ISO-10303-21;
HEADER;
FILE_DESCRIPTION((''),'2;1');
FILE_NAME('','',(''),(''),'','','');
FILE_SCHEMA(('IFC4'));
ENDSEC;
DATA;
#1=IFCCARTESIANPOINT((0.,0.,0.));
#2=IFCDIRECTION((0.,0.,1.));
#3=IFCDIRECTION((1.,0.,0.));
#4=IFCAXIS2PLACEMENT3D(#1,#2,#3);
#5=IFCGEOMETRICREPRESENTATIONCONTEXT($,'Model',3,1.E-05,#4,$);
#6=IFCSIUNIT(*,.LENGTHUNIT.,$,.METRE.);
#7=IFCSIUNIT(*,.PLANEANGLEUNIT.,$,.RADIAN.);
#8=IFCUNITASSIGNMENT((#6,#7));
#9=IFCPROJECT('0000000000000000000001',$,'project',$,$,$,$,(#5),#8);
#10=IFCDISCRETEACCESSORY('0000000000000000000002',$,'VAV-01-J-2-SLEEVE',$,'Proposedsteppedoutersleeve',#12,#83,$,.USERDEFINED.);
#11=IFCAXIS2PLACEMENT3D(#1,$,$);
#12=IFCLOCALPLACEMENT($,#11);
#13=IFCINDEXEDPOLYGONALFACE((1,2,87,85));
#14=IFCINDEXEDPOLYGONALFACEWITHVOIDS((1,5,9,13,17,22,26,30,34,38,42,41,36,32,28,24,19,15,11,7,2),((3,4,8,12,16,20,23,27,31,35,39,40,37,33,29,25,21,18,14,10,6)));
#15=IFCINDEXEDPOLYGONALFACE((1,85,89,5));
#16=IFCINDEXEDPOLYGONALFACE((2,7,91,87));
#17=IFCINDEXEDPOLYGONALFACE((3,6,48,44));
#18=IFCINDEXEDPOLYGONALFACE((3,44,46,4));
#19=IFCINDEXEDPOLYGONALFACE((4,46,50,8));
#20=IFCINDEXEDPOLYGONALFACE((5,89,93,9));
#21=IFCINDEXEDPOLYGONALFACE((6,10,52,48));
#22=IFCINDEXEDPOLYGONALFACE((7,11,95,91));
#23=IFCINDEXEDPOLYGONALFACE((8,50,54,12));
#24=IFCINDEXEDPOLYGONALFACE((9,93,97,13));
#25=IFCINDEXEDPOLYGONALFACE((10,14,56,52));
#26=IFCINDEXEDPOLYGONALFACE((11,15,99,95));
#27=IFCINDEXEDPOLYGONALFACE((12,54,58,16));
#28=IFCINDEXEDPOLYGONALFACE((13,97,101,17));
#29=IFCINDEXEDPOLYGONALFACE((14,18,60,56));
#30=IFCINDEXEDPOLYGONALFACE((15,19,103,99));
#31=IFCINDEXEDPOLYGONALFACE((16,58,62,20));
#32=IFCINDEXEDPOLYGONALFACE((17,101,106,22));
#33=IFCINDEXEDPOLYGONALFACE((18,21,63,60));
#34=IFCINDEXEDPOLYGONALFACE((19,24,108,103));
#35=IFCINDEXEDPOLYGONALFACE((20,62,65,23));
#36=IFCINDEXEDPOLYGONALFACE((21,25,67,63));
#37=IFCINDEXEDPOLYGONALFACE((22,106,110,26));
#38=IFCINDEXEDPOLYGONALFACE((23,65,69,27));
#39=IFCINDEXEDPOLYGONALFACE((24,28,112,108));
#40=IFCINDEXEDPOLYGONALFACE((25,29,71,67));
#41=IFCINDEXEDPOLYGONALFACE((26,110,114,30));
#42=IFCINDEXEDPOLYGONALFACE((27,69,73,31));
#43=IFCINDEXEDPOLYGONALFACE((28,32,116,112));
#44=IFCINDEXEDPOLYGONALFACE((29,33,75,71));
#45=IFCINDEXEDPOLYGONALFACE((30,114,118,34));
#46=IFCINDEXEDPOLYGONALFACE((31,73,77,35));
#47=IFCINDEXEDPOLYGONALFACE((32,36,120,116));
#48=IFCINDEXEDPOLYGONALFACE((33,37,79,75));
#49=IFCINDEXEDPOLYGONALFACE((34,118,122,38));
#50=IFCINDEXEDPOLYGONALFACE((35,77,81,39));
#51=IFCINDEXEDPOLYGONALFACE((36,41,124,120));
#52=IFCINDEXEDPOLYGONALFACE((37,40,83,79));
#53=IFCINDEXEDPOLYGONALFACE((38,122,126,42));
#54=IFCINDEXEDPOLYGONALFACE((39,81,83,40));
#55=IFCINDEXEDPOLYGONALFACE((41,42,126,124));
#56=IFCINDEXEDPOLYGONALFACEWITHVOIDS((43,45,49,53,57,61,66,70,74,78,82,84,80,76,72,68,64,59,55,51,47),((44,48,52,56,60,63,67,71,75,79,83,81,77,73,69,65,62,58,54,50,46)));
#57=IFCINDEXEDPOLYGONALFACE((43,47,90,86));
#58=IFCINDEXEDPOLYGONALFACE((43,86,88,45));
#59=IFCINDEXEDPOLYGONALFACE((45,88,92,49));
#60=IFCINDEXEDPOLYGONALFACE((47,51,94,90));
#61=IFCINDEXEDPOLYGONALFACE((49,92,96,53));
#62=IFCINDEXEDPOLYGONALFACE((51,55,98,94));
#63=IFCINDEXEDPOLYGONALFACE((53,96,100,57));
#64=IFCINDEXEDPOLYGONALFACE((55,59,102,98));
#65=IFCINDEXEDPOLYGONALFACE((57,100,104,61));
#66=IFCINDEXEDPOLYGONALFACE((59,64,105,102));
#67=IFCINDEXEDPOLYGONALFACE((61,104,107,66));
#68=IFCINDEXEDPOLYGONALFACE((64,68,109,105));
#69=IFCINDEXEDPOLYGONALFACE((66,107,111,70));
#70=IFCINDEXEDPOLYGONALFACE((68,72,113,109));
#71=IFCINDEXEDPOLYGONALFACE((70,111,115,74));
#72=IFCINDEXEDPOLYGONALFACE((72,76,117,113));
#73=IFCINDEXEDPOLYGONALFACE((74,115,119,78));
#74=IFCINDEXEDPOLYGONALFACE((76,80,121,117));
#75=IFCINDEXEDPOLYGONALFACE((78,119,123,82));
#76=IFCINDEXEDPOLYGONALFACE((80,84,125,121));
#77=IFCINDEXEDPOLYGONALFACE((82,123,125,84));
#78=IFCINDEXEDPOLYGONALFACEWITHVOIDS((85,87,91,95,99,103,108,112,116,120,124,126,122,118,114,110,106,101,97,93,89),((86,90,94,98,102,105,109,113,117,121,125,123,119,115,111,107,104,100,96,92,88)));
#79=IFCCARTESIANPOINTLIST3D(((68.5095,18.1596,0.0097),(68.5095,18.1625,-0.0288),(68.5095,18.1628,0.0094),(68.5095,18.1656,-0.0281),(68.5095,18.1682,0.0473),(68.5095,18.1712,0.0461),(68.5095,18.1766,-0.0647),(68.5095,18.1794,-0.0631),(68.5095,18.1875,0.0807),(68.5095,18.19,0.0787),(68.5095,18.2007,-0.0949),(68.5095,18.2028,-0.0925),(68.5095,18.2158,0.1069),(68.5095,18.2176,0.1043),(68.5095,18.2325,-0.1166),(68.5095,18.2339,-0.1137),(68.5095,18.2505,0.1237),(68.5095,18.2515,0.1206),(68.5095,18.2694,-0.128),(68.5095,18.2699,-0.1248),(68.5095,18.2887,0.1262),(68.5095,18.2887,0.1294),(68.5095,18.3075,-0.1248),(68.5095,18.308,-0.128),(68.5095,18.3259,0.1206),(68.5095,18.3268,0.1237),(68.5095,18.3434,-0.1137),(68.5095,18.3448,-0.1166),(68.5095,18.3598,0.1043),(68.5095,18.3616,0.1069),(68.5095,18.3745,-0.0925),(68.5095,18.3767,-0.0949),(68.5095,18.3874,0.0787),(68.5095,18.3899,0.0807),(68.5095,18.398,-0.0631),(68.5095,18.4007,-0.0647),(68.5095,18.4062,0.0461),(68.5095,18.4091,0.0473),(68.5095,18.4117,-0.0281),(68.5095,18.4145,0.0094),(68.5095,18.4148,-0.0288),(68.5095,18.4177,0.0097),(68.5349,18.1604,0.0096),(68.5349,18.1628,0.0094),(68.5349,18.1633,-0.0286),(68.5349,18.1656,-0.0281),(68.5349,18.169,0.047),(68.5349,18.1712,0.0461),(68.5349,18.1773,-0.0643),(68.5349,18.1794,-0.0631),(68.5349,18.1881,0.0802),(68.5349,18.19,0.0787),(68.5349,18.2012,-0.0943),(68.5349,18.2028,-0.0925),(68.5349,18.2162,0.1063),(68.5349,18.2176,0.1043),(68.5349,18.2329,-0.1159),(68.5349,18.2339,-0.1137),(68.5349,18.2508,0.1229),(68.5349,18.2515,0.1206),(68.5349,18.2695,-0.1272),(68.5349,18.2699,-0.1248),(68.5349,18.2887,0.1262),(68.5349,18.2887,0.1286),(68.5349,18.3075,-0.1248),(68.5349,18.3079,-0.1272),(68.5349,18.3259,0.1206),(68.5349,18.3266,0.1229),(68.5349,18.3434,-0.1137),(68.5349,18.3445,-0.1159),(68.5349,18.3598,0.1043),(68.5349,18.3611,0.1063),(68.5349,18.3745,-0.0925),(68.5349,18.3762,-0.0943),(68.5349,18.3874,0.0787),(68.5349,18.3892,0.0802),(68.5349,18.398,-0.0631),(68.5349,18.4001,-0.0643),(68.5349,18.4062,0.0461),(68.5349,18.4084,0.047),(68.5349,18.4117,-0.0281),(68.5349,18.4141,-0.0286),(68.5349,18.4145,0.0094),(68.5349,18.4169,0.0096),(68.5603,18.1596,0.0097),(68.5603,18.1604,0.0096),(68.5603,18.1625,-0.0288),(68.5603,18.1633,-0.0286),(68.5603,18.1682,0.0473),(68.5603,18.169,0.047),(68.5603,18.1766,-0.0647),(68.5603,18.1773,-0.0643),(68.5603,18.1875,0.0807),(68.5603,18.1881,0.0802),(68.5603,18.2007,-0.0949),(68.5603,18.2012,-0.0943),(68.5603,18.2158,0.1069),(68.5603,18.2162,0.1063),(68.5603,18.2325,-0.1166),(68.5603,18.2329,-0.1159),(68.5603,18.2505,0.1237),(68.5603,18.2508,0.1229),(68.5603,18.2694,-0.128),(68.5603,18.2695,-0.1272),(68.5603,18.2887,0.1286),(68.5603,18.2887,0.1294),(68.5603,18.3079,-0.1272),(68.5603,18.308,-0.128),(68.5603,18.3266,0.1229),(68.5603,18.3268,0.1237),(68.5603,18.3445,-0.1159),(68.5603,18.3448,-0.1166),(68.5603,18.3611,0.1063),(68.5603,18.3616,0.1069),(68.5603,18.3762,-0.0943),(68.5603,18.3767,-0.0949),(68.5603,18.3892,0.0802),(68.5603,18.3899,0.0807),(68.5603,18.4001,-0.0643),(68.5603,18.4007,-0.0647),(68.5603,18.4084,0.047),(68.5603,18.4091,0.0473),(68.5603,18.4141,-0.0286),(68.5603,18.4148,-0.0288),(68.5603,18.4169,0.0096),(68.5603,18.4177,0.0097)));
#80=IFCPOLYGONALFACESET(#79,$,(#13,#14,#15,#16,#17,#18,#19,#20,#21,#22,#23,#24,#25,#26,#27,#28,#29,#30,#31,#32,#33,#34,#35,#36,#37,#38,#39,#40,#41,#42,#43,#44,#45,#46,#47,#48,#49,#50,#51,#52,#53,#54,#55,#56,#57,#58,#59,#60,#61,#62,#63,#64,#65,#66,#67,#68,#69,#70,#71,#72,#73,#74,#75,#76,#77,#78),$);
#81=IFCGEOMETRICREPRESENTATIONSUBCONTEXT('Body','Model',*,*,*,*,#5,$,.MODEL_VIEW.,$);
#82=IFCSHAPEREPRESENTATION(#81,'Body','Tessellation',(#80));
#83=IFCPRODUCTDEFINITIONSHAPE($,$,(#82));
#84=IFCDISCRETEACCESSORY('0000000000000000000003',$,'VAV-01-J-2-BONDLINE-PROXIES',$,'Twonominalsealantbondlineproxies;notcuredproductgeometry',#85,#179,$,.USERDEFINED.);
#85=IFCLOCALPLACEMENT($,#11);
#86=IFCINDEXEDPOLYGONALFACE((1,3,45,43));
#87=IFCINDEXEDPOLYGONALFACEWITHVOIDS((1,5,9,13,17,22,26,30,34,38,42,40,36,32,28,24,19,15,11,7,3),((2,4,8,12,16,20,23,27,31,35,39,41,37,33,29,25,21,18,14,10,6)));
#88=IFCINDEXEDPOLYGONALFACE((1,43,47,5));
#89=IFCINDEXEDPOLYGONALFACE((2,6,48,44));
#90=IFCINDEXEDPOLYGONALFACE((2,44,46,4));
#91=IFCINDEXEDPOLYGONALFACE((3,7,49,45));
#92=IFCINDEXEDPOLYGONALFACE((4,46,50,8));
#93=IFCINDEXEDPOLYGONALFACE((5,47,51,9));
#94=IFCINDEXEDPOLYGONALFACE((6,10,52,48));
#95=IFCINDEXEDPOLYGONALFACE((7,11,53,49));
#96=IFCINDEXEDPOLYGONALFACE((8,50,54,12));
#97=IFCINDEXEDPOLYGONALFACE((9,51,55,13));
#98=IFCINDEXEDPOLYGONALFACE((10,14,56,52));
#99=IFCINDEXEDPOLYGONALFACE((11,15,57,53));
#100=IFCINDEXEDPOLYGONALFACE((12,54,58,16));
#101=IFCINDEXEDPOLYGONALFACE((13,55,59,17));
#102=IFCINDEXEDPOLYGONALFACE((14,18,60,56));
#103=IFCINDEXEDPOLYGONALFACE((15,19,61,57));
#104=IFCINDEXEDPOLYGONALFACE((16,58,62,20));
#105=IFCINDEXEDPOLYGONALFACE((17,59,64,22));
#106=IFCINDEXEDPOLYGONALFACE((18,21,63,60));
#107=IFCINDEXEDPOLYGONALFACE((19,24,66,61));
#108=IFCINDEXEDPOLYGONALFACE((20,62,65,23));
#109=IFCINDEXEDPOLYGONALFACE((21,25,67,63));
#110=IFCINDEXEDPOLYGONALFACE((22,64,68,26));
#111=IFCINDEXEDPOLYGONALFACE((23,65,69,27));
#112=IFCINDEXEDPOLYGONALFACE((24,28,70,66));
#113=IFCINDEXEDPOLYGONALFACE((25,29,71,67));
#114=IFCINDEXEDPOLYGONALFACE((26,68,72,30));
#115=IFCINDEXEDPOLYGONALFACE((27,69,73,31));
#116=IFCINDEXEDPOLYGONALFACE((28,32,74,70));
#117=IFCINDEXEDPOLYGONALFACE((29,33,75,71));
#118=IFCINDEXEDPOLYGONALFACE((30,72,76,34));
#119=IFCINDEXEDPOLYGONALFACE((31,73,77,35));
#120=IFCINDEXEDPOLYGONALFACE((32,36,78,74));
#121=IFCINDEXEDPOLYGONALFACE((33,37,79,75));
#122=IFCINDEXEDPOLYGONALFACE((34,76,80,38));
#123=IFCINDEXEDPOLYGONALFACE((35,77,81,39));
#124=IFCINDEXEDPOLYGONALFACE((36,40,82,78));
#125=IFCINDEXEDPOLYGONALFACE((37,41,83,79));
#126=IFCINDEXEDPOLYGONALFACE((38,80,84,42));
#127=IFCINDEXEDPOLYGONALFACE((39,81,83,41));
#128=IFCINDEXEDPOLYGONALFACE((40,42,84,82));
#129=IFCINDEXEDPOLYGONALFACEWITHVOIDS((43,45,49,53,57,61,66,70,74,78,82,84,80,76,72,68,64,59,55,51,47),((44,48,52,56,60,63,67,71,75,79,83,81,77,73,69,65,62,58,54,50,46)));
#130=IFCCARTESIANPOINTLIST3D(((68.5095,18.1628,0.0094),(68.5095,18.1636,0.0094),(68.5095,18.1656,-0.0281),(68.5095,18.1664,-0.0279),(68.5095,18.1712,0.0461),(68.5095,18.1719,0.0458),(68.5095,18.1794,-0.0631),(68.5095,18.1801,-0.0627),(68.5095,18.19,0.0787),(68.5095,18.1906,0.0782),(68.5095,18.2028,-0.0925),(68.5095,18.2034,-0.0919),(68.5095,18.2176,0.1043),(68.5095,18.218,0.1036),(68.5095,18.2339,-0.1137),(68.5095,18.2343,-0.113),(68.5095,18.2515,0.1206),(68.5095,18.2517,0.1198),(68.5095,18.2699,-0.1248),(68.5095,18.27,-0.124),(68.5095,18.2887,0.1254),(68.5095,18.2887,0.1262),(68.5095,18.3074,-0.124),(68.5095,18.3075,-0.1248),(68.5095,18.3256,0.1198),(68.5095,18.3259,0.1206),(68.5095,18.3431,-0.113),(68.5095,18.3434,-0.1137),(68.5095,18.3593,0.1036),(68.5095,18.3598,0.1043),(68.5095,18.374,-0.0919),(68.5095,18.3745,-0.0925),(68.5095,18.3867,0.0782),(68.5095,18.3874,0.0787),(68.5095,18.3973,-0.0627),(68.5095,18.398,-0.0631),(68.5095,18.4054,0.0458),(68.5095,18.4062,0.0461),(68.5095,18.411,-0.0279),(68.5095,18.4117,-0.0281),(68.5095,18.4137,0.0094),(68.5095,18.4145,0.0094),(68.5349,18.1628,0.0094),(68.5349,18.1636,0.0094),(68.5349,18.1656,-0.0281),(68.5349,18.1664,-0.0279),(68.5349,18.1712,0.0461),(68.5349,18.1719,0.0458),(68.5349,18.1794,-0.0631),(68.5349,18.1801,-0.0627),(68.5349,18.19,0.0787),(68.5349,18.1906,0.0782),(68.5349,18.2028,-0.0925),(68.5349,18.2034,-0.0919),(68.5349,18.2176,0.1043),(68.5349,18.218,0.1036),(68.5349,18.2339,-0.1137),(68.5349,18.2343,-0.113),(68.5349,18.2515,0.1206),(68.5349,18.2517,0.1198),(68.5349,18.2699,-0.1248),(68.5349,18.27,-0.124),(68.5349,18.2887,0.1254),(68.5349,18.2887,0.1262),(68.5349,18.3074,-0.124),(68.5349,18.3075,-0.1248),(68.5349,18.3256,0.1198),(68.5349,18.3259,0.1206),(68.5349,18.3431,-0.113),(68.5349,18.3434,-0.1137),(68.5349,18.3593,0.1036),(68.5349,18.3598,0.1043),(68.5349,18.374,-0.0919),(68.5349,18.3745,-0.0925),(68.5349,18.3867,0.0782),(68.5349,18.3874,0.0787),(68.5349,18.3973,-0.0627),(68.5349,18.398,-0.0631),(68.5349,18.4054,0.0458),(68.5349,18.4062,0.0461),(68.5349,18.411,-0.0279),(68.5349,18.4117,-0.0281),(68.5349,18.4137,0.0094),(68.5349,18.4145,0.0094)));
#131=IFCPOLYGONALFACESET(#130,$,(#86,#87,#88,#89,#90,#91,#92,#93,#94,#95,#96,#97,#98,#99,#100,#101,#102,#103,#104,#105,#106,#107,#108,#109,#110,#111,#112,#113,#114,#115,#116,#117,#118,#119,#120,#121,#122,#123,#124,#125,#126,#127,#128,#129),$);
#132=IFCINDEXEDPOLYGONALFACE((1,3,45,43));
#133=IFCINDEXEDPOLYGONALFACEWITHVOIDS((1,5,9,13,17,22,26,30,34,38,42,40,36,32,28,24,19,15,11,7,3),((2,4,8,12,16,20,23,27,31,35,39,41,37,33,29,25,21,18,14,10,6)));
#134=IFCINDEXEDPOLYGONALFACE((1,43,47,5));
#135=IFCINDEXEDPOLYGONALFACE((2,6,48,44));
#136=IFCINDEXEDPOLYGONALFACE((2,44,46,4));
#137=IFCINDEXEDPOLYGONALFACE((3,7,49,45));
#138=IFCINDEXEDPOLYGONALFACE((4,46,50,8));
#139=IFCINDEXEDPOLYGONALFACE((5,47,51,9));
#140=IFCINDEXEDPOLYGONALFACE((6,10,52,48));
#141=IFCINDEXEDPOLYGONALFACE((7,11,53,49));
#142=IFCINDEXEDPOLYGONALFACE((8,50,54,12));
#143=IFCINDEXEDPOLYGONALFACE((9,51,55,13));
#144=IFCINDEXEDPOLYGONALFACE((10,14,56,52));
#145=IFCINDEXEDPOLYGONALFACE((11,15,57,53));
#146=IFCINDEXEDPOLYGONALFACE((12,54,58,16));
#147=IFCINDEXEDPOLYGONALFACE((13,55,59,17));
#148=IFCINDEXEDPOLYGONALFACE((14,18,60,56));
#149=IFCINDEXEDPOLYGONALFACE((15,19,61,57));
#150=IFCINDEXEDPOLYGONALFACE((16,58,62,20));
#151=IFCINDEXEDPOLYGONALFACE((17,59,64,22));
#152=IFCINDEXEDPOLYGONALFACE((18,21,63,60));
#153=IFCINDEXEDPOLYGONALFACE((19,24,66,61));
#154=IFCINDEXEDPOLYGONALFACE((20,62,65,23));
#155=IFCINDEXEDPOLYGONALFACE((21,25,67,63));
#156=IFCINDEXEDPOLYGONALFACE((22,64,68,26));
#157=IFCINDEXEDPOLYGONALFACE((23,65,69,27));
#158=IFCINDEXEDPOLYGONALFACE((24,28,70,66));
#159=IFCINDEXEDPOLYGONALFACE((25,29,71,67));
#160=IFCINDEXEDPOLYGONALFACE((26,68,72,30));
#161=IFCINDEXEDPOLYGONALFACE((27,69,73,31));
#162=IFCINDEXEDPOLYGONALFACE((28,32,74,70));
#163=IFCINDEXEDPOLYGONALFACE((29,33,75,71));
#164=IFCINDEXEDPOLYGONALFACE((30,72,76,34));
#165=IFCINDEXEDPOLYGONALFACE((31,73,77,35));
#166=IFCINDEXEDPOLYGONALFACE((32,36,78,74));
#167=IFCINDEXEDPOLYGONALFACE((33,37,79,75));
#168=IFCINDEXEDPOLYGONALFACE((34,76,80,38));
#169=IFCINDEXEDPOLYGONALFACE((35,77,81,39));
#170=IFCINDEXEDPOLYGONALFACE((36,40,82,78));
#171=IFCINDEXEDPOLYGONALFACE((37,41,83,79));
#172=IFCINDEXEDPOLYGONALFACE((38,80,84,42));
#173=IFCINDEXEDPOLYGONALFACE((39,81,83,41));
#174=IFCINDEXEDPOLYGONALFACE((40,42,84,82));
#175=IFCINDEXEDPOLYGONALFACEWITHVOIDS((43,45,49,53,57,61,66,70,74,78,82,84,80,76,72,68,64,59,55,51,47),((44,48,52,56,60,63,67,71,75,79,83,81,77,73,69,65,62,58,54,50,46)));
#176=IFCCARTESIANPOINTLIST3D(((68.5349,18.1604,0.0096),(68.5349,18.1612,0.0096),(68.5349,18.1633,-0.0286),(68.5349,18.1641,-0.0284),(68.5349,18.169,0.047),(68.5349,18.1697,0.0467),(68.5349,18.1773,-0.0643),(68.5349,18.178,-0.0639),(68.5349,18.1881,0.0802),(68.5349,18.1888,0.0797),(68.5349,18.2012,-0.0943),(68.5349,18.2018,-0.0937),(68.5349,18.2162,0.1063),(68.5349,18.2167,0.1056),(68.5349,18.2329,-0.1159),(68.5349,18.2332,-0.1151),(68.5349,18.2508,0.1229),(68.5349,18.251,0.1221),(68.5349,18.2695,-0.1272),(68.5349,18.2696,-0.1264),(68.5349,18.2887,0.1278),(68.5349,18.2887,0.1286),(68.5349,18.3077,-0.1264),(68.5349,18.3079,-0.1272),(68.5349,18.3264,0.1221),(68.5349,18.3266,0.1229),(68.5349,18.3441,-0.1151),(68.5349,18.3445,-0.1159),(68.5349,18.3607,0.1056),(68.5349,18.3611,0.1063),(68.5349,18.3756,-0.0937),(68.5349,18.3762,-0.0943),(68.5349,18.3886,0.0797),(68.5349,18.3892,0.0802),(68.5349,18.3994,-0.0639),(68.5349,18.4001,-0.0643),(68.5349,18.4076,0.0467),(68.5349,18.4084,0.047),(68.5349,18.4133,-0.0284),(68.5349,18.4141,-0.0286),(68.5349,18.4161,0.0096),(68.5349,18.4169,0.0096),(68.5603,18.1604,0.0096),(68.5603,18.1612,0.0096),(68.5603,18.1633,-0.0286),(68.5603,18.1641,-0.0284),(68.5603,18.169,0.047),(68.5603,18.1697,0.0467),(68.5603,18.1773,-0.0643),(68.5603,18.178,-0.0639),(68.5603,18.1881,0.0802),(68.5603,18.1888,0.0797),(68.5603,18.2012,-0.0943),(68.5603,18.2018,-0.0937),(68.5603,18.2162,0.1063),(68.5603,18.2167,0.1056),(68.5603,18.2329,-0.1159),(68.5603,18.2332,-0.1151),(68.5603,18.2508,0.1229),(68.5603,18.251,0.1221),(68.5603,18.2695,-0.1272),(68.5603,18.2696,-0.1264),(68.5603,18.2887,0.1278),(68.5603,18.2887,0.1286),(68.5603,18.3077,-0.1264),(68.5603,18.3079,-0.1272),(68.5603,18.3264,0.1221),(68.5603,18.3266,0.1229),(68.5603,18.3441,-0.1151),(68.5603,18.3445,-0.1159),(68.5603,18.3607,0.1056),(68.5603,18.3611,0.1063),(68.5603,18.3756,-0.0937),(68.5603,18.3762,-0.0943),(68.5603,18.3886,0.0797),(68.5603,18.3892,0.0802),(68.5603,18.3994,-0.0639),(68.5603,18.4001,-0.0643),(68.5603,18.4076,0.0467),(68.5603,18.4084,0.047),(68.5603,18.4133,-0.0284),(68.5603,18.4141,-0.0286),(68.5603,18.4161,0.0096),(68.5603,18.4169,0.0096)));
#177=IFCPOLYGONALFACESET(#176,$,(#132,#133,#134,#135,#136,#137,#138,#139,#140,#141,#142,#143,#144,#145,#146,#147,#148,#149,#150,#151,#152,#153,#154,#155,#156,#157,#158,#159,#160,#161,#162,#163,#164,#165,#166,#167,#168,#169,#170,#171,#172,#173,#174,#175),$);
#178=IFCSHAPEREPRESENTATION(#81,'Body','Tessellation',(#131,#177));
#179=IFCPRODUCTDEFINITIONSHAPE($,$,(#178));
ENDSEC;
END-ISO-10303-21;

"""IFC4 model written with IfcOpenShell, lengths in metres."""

from ifc_helpers import new_model, entity, si_unit, frame, origin_with_axes, place, context, subcontext, project, element, save


model = new_model("IFC4")

# Units and contexts
model_context = context("Model", 3, precision=1e-05, world=origin_with_axes())
body_context = subcontext(model_context, "Body", "Model", "MODEL_VIEW")
ifc_project = project(units=[si_unit("LENGTHUNIT", "METRE"), si_unit("PLANEANGLEUNIT", "RADIAN")], contexts=[model_context])

# Discrete accessories
discrete_accessory_1_placement = place(None, frame((68.5349, 18.2887, 0.0), z_axis=(0.0, 1.0, 0.0), x_axis=(0.0, 0.0, 1.0)))
element("IfcDiscreteAccessory", 1, at=discrete_accessory_1_placement, Name="VAV-01-J-2-SLEEVE", ObjectType="Proposedsteppedoutersleeve", PredefinedType="USERDEFINED", context=body_context, shape_type="SweptSolid", body=[
    entity("IfcRevolvedAreaSolid", entity("IfcArbitraryClosedProfileDef", "AREA", None, entity("IfcPolyline", [entity("IfcCartesianPoint", [0.1262, -0.0254]), entity("IfcCartesianPoint", [0.1294, -0.0254]), entity("IfcCartesianPoint", [0.1294, 0.0254]), entity("IfcCartesianPoint", [0.1286, 0.0254]), entity("IfcCartesianPoint", [0.1286, 0.0]), entity("IfcCartesianPoint", [0.1262, 0.0]), entity("IfcCartesianPoint", [0.1262, -0.0254])])), entity("IfcAxis2Placement3D", entity("IfcCartesianPoint", [0.0, 0.0, 0.0])), entity("IfcAxis1Placement", entity("IfcCartesianPoint", [0.0, 0.0, 0.0]), entity("IfcDirection", [0.0, 1.0, 0.0])), 6.283185),
])
discrete_accessory_2_placement = place(None, frame((68.5349, 18.2887, 0.0), z_axis=(0.0, 1.0, 0.0), x_axis=(0.0, 0.0, 1.0)))
element("IfcDiscreteAccessory", 2, at=discrete_accessory_2_placement, Name="VAV-01-J-2-BONDLINE-PROXIES", ObjectType="Twonominalsealantbondlineproxies;notcuredproductgeometry", PredefinedType="USERDEFINED", context=body_context, shape_type="SweptSolid", body=[
    entity("IfcRevolvedAreaSolid", entity("IfcArbitraryClosedProfileDef", "AREA", None, entity("IfcPolyline", [entity("IfcCartesianPoint", [0.1254, -0.0254]), entity("IfcCartesianPoint", [0.1262, -0.0254]), entity("IfcCartesianPoint", [0.1262, 0.0]), entity("IfcCartesianPoint", [0.1254, 0.0]), entity("IfcCartesianPoint", [0.1254, -0.0254])])), entity("IfcAxis2Placement3D", entity("IfcCartesianPoint", [0.0, 0.0, 0.0])), entity("IfcAxis1Placement", entity("IfcCartesianPoint", [0.0, 0.0, 0.0]), entity("IfcDirection", [0.0, 1.0, 0.0])), 6.283185),
    entity("IfcRevolvedAreaSolid", entity("IfcArbitraryClosedProfileDef", "AREA", None, entity("IfcPolyline", [entity("IfcCartesianPoint", [0.1278, 0.0]), entity("IfcCartesianPoint", [0.1286, 0.0]), entity("IfcCartesianPoint", [0.1286, 0.0254]), entity("IfcCartesianPoint", [0.1278, 0.0254]), entity("IfcCartesianPoint", [0.1278, 0.0])])), entity("IfcAxis2Placement3D", entity("IfcCartesianPoint", [0.0, 0.0, 0.0])), entity("IfcAxis1Placement", entity("IfcCartesianPoint", [0.0, 0.0, 0.0]), entity("IfcDirection", [0.0, 1.0, 0.0])), 6.283185),
])

save(model, "model.ifc")
